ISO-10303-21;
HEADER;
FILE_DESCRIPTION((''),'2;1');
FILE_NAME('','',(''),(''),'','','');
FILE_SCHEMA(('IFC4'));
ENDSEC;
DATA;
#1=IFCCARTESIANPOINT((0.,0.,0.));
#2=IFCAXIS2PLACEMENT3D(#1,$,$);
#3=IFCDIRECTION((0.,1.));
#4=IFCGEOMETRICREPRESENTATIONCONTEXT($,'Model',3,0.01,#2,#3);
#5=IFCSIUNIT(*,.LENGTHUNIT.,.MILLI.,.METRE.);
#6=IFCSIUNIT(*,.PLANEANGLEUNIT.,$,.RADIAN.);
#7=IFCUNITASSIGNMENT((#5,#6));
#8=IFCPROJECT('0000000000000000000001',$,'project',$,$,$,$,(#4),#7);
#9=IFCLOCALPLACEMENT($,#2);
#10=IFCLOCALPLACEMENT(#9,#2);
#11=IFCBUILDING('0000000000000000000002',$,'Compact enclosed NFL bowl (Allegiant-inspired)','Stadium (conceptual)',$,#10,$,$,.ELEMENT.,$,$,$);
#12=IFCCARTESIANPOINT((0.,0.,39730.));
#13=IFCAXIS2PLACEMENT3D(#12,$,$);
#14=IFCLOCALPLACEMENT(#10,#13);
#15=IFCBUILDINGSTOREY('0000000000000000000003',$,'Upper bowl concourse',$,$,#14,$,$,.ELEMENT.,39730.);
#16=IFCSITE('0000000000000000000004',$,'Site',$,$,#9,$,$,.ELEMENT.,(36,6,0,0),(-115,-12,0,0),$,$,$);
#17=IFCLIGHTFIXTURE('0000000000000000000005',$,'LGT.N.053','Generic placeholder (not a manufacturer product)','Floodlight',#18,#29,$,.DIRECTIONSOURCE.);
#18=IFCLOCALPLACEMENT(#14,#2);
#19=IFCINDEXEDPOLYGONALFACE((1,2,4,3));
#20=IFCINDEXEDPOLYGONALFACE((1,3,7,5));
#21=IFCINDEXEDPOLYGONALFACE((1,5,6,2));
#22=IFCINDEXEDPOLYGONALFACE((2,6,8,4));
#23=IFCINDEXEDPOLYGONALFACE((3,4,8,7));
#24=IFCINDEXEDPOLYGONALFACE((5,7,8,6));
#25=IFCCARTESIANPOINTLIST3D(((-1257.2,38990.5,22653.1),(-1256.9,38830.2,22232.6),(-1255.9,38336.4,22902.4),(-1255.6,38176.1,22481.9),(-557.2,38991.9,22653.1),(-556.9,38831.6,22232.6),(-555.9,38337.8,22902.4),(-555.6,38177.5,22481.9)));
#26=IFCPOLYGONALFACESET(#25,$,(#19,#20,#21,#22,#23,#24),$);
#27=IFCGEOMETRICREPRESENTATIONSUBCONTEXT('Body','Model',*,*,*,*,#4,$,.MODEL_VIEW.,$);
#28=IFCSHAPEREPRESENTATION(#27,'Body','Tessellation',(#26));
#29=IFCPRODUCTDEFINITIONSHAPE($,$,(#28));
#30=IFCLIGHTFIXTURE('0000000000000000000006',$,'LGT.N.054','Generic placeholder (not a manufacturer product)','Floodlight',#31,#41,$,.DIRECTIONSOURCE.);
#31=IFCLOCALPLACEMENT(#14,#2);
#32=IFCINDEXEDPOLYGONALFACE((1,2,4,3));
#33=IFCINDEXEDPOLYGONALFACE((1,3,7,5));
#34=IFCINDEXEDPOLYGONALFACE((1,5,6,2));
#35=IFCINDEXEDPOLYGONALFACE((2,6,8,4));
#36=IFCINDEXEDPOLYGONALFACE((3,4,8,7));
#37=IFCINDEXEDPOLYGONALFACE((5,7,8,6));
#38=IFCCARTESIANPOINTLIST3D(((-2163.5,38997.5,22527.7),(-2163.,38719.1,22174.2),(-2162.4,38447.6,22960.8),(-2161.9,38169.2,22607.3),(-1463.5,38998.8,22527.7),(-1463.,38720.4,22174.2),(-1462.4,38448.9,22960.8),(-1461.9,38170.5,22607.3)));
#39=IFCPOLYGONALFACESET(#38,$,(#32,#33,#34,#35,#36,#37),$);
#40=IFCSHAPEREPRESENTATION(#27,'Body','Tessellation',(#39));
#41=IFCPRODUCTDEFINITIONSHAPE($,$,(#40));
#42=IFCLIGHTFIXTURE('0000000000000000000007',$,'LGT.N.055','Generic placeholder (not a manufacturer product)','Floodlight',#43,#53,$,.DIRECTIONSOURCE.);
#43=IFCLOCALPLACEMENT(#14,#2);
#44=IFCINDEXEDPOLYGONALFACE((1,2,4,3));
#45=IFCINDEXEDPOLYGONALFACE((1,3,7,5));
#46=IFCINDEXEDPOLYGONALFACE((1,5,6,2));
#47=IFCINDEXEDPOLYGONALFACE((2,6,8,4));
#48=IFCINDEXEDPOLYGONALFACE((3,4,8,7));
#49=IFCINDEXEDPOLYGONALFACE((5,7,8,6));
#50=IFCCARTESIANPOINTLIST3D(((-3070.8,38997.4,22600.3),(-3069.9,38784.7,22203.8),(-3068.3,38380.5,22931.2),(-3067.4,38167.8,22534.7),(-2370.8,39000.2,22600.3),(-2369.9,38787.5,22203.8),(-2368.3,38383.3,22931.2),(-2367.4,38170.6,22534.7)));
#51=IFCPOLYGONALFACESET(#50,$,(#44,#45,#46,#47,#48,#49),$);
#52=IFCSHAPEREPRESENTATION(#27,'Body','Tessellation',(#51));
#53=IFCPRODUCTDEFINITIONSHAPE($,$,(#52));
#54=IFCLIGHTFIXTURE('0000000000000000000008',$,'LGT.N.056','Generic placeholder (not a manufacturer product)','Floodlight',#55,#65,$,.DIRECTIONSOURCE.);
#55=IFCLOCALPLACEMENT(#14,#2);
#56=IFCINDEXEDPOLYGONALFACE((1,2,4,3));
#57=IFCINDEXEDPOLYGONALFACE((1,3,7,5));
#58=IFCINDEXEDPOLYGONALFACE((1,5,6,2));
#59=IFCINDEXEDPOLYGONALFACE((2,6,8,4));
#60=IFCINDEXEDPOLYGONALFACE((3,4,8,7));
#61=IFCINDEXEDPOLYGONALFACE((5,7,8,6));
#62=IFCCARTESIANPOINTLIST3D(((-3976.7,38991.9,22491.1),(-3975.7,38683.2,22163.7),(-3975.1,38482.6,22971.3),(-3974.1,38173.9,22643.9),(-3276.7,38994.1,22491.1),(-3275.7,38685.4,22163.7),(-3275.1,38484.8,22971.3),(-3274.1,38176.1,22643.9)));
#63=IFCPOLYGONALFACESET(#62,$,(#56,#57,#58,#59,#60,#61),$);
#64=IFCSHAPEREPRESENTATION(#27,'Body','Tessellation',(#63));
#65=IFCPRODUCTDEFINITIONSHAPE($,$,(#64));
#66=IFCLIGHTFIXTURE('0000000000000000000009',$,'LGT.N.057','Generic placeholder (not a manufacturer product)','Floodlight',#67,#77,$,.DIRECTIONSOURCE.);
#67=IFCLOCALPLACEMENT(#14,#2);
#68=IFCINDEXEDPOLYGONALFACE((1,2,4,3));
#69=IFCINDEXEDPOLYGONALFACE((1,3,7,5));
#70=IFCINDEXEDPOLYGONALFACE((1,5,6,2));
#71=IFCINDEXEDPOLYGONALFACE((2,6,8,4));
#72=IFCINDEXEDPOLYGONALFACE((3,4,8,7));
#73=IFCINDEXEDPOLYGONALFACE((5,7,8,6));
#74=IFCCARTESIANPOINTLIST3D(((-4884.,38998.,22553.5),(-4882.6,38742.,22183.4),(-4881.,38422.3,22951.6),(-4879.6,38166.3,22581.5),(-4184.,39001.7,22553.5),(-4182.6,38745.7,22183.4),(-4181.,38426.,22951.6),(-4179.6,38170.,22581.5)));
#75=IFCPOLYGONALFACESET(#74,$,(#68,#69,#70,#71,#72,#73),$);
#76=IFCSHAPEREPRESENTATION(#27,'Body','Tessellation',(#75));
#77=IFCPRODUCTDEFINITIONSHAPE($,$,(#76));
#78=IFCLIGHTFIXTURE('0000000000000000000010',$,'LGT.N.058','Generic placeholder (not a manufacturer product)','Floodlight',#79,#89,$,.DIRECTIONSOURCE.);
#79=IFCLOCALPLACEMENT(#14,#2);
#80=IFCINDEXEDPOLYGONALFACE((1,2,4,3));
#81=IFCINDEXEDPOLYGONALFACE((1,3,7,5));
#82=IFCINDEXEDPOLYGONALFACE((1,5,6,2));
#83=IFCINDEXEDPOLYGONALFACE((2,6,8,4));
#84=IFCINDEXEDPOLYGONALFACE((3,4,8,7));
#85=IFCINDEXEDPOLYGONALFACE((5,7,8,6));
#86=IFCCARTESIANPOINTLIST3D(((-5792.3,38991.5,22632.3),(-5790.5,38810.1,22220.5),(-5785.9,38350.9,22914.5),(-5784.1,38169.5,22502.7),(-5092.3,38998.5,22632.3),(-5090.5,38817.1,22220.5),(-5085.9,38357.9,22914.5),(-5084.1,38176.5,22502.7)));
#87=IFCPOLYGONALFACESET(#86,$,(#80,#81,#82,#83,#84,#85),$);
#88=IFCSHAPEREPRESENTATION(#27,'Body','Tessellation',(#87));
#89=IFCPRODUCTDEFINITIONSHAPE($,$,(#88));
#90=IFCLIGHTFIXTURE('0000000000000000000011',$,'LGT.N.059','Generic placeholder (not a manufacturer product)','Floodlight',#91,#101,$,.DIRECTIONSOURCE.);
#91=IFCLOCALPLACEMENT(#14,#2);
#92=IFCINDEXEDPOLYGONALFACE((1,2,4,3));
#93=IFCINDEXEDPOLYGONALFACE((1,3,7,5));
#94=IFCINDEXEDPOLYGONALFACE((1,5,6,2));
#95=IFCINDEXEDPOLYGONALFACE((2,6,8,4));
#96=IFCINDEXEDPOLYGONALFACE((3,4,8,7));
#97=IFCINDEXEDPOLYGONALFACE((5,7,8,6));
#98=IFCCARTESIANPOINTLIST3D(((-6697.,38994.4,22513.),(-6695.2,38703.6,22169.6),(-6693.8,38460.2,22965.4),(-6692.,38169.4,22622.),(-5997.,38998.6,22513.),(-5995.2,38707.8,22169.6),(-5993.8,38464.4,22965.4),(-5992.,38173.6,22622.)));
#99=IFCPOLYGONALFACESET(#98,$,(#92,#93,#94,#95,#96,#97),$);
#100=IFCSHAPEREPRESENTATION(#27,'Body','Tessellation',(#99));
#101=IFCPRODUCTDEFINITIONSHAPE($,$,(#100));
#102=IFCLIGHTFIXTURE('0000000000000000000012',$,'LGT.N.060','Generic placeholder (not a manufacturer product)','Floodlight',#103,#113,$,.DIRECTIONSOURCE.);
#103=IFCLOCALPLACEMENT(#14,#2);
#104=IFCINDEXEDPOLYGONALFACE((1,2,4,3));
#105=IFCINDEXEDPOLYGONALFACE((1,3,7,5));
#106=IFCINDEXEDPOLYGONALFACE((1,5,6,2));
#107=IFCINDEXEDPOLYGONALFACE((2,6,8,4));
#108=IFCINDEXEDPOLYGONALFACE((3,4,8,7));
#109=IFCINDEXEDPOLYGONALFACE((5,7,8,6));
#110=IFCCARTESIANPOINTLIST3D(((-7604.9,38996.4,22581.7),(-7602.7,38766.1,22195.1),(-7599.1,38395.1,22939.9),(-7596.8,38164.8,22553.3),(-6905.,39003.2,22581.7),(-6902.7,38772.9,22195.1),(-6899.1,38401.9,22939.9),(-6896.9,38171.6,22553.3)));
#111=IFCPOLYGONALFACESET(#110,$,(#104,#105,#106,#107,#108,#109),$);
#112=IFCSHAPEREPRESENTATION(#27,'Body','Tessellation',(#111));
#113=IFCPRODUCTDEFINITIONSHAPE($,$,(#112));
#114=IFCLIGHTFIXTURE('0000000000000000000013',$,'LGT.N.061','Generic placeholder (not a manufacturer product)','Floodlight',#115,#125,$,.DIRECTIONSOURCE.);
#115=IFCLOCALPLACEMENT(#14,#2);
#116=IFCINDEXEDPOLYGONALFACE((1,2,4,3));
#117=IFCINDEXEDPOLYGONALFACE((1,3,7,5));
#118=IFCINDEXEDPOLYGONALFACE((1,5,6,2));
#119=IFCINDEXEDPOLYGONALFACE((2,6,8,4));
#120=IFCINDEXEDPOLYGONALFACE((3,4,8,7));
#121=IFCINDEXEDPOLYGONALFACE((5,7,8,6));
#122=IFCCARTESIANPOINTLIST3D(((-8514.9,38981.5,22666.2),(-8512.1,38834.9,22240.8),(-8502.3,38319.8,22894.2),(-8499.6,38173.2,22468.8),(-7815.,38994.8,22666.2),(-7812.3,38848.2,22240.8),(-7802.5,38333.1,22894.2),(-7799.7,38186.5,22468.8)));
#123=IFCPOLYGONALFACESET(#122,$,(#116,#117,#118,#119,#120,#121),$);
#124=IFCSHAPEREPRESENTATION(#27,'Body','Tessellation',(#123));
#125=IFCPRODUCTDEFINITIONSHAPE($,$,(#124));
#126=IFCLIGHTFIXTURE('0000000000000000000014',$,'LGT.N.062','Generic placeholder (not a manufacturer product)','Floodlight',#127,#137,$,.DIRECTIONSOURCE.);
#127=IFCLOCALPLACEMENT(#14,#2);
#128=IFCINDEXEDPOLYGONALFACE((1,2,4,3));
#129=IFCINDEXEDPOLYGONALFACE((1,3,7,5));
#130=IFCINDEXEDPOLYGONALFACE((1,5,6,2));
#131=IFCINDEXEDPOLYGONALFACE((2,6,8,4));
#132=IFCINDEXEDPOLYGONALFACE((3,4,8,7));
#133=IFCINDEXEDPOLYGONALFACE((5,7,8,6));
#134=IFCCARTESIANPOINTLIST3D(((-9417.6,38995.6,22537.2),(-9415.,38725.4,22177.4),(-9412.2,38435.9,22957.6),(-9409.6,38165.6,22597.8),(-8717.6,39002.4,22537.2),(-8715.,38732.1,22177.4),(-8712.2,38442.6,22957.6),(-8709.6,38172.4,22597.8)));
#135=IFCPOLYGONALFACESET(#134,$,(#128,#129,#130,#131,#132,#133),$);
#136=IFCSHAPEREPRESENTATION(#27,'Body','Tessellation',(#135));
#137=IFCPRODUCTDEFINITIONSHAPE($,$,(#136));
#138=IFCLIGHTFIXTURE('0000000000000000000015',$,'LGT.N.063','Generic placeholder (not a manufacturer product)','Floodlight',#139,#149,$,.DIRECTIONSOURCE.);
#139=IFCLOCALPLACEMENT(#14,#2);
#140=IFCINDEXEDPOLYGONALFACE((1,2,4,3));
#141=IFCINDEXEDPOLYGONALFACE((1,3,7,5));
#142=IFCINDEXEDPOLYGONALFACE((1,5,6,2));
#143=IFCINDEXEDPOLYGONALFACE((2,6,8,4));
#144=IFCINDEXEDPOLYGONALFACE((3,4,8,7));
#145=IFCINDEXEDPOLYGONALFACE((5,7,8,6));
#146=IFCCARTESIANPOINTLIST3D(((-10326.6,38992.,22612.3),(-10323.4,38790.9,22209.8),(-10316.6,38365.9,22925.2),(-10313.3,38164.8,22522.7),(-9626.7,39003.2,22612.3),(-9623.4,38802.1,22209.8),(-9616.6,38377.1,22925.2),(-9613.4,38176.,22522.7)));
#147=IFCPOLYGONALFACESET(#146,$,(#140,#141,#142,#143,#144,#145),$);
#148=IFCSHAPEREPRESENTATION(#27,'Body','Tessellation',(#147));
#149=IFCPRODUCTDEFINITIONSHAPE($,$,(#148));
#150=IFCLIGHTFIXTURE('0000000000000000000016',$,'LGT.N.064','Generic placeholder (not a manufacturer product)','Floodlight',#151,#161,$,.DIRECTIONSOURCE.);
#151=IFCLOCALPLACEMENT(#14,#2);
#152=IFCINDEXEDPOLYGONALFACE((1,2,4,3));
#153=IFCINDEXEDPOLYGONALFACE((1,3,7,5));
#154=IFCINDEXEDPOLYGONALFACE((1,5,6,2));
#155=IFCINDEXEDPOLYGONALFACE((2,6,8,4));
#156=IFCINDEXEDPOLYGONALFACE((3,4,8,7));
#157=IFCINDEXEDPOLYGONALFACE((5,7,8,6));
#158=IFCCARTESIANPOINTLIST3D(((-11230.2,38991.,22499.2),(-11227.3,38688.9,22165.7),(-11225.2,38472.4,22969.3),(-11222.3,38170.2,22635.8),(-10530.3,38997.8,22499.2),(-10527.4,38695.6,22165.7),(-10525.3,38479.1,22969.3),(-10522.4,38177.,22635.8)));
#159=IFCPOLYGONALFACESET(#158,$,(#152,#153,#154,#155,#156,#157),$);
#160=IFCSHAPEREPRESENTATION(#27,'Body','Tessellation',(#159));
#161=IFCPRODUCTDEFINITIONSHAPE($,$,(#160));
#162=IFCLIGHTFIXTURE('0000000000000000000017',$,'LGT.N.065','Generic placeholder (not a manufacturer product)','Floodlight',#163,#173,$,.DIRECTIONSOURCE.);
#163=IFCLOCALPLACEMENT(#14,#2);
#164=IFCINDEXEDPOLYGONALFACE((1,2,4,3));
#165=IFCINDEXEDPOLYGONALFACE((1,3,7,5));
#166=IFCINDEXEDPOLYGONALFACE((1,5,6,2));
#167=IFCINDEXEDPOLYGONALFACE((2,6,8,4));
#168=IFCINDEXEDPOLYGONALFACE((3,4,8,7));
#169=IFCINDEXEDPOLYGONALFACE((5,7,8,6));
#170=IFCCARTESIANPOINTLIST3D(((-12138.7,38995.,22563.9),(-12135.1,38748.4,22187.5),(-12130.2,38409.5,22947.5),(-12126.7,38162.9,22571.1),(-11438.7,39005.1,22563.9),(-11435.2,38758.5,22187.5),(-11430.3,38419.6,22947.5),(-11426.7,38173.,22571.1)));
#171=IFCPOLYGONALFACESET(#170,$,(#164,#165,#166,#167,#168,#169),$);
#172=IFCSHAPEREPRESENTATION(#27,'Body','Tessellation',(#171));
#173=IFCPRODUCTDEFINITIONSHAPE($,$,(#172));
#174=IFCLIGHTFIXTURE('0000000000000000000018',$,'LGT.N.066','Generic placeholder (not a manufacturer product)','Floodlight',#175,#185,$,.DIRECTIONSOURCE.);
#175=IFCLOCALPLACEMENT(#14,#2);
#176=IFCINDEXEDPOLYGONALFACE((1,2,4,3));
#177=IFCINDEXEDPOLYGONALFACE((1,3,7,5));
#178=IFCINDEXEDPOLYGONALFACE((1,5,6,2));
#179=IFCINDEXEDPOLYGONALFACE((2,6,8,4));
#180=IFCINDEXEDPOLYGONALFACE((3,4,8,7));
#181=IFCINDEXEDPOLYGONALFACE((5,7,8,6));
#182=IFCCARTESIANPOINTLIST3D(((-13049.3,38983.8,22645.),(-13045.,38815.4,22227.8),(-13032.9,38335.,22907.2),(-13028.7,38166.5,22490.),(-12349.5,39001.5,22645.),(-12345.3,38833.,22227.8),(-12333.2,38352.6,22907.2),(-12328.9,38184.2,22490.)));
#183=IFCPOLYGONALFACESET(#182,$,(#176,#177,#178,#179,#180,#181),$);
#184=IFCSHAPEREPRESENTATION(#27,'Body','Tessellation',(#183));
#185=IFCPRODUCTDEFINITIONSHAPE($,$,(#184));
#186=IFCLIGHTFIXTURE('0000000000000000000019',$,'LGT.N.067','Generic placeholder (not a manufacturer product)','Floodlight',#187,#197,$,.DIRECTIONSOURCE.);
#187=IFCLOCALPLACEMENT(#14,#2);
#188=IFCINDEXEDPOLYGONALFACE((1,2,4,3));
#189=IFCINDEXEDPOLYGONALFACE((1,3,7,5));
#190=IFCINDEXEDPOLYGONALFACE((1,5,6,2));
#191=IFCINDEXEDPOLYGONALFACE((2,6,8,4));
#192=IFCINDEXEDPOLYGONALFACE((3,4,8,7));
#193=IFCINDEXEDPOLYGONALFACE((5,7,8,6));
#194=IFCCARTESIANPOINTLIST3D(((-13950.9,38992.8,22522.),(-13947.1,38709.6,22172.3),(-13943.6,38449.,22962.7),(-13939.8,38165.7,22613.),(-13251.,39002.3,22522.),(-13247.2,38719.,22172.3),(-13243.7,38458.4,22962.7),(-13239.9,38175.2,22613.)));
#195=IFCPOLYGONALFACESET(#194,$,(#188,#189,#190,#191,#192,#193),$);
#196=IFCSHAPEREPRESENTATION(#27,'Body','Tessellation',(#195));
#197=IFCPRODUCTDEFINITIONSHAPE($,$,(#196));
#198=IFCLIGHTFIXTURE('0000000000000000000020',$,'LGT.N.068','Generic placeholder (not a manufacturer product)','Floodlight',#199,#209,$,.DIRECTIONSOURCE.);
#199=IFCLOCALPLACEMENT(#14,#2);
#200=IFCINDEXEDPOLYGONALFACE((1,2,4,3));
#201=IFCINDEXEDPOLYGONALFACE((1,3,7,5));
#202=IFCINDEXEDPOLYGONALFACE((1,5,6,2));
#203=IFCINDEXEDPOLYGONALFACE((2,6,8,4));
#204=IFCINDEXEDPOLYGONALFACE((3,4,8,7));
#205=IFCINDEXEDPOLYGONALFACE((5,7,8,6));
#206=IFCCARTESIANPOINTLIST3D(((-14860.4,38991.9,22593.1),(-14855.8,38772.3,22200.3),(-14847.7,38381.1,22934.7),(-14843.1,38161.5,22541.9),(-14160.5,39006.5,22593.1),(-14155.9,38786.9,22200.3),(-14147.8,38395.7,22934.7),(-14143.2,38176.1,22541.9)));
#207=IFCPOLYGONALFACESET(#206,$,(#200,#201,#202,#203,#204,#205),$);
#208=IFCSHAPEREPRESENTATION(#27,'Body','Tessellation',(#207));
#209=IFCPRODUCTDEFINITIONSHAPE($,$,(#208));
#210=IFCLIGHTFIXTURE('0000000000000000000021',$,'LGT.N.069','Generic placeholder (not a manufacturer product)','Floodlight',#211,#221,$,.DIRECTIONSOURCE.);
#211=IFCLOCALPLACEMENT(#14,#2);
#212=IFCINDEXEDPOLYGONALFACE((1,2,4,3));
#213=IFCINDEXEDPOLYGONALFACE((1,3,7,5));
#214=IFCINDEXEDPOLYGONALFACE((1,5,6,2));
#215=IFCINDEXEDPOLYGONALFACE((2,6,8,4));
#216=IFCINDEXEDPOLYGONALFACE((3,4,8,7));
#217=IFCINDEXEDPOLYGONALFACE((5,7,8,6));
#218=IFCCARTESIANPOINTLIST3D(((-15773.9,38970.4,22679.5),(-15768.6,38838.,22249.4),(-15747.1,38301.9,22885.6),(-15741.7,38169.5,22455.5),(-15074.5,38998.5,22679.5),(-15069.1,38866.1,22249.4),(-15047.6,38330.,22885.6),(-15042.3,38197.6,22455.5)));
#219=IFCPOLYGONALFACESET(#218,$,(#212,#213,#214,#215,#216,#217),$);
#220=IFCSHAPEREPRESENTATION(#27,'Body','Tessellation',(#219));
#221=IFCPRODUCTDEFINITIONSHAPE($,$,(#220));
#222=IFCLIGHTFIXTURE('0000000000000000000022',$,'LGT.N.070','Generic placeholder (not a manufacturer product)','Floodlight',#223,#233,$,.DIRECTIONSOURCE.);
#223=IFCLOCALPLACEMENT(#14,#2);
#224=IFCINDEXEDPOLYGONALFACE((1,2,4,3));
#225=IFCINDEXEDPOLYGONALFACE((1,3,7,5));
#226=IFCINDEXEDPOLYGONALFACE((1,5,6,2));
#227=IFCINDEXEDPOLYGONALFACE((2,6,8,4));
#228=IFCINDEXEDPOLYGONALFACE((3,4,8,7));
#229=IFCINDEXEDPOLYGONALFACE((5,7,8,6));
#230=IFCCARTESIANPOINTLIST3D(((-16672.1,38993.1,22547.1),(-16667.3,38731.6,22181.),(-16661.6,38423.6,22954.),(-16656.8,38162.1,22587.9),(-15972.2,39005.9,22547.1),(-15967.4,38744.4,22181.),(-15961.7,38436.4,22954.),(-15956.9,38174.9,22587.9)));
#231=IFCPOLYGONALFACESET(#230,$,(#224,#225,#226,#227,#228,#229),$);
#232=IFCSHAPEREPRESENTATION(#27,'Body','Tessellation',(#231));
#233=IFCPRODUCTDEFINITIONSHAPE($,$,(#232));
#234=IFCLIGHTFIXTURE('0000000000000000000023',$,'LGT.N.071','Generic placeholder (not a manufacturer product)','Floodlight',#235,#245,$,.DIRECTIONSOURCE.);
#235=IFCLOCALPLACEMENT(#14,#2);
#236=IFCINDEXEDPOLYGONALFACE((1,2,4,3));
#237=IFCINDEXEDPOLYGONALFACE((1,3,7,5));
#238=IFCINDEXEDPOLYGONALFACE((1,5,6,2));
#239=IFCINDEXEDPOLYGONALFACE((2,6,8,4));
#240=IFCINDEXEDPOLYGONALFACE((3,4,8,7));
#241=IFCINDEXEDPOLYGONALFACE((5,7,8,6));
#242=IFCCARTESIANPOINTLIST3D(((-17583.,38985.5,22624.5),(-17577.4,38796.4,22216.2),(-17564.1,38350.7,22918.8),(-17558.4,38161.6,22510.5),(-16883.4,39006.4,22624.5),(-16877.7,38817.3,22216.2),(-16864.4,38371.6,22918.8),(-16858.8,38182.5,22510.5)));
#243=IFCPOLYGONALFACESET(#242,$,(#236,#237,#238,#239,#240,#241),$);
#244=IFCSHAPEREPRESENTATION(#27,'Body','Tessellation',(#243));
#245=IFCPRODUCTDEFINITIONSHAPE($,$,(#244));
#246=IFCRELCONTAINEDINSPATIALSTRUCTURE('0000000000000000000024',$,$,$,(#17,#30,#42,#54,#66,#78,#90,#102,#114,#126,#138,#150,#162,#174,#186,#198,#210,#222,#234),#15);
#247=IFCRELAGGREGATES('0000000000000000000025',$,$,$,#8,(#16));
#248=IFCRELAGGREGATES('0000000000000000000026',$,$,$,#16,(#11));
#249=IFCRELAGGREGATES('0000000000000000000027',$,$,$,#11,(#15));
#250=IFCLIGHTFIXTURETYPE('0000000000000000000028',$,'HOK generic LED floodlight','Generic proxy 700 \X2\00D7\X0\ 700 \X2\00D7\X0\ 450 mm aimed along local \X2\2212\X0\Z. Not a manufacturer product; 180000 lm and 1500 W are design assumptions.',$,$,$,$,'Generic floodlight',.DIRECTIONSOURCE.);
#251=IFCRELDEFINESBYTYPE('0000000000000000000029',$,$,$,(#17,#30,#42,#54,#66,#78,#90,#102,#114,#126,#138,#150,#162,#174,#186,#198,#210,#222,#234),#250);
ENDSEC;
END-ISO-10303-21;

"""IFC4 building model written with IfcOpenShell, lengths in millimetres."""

from ifc_helpers import new_model, si_unit, direction, frame, origin, place, context, subcontext, project, spatial, rectangle, extrude, source, transform, mapped, type_object, type_shapes, element, save


model = new_model("IFC4")

# Units and contexts
model_context = context("Model", 3, precision=0.01, world=origin(), true_north=direction((0.0, 1.0)))
body_context = subcontext(model_context, "Body", "Model", "MODEL_VIEW")
ifc_project = project(units=[si_unit("LENGTHUNIT", "METRE", prefix="MILLI"), si_unit("PLANEANGLEUNIT", "RADIAN")], contexts=[model_context])

# Site, building, storey
site_placement = place(None, origin())
site = spatial("IfcSite", under=ifc_project, at=site_placement, Name="Site", CompositionType="ELEMENT", RefLatitude=(36, 6, 0, 0), RefLongitude=(-115, -12, 0, 0))
building_placement = place(site_placement, origin())
building = spatial("IfcBuilding", under=site, at=building_placement, Name="Compact enclosed NFL bowl (Allegiant-inspired)", Description="Stadium (conceptual)", CompositionType="ELEMENT")
storey_placement = place(building_placement, frame((0.0, 0.0, 39730.0)))
storey = spatial("IfcBuildingStorey", under=building, at=storey_placement, Name="Upper bowl concourse", CompositionType="ELEMENT", Elevation=39730.0)

# Light fixtures
light_fixture_type = type_object("IfcLightFixtureType", Name="HOK generic LED floodlight", Description="Generic proxy 700 × 700 × 450 mm aimed along local −Z. Not a manufacturer product; 180000 lm and 1500 W are design assumptions.", ElementType="Generic floodlight", PredefinedType="DIRECTIONSOURCE")
shared_shape = source(origin(), body_context, "Body", "SweptSolid", [
    extrude(rectangle(XDim=700.0, YDim=700.0), frame((0.0, 0.0, -225.0)), (0.0, 0.0, 1.0), 450.0),
])
type_shapes(light_fixture_type, [shared_shape])
for number, where, z_axis, x_axis, name in (
    (1, (-906.4, 38584.0, 22567.5), (-0.00068, 0.356162, 0.934424), (-0.999998, -0.001909, 0.0), "LGT.N.053"),
    (2, (-1812.7, 38584.0, 22567.5), (-0.001143, 0.618717, 0.785613), (-0.999998, -0.001847, 0.0), "LGT.N.054"),
    (3, (-2719.1, 38584.0, 22567.5), (-0.001923, 0.472682, 0.881231), (-0.999992, -0.004069, 0.0), "LGT.N.055"),
    (4, (-3625.4, 38584.0, 22567.5), (-0.002117, 0.685986, 0.727612), (-0.999995, -0.003086, 0.0), "LGT.N.056"),
    (5, (-4531.8, 38584.0, 22567.5), (-0.002991, 0.568825, 0.822453), (-0.999986, -0.005259, 0.0), "LGT.N.057"),
    (6, (-5438.2, 38584.0, 22567.5), (-0.003994, 0.40308, 0.915156), (-0.999951, -0.009909, 0.0), "LGT.N.058"),
    (7, (-6344.5, 38584.0, 22567.5), (-0.003886, 0.646248, 0.763118), (-0.999982, -0.006013, 0.0), "LGT.N.059"),
    (8, (-7250.9, 38584.0, 22567.5), (-0.005, 0.511759, 0.859115), (-0.999952, -0.009769, 0.0), "LGT.N.060"),
    (9, (-8157.3, 38584.0, 22567.5), (-0.00619, 0.325717, 0.945447), (-0.999819, -0.019, 0.0), "LGT.N.061"),
    (10, (-9063.6, 38584.0, 22567.5), (-0.005817, 0.600457, 0.799636), (-0.999953, -0.009687, 0.0), "LGT.N.062"),
    (11, (-9970.0, 38584.0, 22567.5), (-0.007158, 0.447018, 0.894496), (-0.999872, -0.01601, 0.0), "LGT.N.063"),
    (12, (-10876.3, 38584.0, 22567.5), (-0.006469, 0.671463, 0.74101), (-0.999954, -0.009633, 0.0), "LGT.N.064"),
    (13, (-11782.7, 38584.0, 22567.5), (-0.007911, 0.547894, 0.836511), (-0.999896, -0.014437, 0.0), "LGT.N.065"),
    (14, (-12689.1, 38584.0, 22567.5), (-0.009443, 0.374413, 0.927214), (-0.999682, -0.025213, 0.0), "LGT.N.066"),
    (15, (-13595.4, 38584.0, 22567.5), (-0.008478, 0.629496, 0.776957), (-0.999909, -0.013467, 0.0), "LGT.N.067"),
    (16, (-14501.8, 38584.0, 22567.5), (-0.010159, 0.487938, 0.872819), (-0.999783, -0.020815, 0.0), "LGT.N.068"),
    (17, (-15408.1, 38584.0, 22567.5), (-0.011818, 0.294217, 0.955666), (-0.999194, -0.040136, 0.0), "LGT.N.069"),
    (18, (-16314.5, 38584.0, 22567.5), (-0.010655, 0.581196, 0.813694), (-0.999832, -0.018329, 0.0), "LGT.N.070"),
    (19, (-17220.9, 38584.0, 22567.5), (-0.012541, 0.420191, 0.907349), (-0.999555, -0.029832, 0.0), "LGT.N.071"),
):
    element("IfcLightFixture", number, at=place(storey_placement, frame(where, z_axis=z_axis, x_axis=x_axis)), inside=storey, type_object=light_fixture_type, Name=name, Description="Generic placeholder (not a manufacturer product)", ObjectType="Floodlight", PredefinedType="DIRECTIONSOURCE", context=body_context, shape_type="MappedRepresentation", body=[
        mapped(shared_shape, transform((0.0, 0.0, 0.0))),
    ])

save(model, "model.ifc")
